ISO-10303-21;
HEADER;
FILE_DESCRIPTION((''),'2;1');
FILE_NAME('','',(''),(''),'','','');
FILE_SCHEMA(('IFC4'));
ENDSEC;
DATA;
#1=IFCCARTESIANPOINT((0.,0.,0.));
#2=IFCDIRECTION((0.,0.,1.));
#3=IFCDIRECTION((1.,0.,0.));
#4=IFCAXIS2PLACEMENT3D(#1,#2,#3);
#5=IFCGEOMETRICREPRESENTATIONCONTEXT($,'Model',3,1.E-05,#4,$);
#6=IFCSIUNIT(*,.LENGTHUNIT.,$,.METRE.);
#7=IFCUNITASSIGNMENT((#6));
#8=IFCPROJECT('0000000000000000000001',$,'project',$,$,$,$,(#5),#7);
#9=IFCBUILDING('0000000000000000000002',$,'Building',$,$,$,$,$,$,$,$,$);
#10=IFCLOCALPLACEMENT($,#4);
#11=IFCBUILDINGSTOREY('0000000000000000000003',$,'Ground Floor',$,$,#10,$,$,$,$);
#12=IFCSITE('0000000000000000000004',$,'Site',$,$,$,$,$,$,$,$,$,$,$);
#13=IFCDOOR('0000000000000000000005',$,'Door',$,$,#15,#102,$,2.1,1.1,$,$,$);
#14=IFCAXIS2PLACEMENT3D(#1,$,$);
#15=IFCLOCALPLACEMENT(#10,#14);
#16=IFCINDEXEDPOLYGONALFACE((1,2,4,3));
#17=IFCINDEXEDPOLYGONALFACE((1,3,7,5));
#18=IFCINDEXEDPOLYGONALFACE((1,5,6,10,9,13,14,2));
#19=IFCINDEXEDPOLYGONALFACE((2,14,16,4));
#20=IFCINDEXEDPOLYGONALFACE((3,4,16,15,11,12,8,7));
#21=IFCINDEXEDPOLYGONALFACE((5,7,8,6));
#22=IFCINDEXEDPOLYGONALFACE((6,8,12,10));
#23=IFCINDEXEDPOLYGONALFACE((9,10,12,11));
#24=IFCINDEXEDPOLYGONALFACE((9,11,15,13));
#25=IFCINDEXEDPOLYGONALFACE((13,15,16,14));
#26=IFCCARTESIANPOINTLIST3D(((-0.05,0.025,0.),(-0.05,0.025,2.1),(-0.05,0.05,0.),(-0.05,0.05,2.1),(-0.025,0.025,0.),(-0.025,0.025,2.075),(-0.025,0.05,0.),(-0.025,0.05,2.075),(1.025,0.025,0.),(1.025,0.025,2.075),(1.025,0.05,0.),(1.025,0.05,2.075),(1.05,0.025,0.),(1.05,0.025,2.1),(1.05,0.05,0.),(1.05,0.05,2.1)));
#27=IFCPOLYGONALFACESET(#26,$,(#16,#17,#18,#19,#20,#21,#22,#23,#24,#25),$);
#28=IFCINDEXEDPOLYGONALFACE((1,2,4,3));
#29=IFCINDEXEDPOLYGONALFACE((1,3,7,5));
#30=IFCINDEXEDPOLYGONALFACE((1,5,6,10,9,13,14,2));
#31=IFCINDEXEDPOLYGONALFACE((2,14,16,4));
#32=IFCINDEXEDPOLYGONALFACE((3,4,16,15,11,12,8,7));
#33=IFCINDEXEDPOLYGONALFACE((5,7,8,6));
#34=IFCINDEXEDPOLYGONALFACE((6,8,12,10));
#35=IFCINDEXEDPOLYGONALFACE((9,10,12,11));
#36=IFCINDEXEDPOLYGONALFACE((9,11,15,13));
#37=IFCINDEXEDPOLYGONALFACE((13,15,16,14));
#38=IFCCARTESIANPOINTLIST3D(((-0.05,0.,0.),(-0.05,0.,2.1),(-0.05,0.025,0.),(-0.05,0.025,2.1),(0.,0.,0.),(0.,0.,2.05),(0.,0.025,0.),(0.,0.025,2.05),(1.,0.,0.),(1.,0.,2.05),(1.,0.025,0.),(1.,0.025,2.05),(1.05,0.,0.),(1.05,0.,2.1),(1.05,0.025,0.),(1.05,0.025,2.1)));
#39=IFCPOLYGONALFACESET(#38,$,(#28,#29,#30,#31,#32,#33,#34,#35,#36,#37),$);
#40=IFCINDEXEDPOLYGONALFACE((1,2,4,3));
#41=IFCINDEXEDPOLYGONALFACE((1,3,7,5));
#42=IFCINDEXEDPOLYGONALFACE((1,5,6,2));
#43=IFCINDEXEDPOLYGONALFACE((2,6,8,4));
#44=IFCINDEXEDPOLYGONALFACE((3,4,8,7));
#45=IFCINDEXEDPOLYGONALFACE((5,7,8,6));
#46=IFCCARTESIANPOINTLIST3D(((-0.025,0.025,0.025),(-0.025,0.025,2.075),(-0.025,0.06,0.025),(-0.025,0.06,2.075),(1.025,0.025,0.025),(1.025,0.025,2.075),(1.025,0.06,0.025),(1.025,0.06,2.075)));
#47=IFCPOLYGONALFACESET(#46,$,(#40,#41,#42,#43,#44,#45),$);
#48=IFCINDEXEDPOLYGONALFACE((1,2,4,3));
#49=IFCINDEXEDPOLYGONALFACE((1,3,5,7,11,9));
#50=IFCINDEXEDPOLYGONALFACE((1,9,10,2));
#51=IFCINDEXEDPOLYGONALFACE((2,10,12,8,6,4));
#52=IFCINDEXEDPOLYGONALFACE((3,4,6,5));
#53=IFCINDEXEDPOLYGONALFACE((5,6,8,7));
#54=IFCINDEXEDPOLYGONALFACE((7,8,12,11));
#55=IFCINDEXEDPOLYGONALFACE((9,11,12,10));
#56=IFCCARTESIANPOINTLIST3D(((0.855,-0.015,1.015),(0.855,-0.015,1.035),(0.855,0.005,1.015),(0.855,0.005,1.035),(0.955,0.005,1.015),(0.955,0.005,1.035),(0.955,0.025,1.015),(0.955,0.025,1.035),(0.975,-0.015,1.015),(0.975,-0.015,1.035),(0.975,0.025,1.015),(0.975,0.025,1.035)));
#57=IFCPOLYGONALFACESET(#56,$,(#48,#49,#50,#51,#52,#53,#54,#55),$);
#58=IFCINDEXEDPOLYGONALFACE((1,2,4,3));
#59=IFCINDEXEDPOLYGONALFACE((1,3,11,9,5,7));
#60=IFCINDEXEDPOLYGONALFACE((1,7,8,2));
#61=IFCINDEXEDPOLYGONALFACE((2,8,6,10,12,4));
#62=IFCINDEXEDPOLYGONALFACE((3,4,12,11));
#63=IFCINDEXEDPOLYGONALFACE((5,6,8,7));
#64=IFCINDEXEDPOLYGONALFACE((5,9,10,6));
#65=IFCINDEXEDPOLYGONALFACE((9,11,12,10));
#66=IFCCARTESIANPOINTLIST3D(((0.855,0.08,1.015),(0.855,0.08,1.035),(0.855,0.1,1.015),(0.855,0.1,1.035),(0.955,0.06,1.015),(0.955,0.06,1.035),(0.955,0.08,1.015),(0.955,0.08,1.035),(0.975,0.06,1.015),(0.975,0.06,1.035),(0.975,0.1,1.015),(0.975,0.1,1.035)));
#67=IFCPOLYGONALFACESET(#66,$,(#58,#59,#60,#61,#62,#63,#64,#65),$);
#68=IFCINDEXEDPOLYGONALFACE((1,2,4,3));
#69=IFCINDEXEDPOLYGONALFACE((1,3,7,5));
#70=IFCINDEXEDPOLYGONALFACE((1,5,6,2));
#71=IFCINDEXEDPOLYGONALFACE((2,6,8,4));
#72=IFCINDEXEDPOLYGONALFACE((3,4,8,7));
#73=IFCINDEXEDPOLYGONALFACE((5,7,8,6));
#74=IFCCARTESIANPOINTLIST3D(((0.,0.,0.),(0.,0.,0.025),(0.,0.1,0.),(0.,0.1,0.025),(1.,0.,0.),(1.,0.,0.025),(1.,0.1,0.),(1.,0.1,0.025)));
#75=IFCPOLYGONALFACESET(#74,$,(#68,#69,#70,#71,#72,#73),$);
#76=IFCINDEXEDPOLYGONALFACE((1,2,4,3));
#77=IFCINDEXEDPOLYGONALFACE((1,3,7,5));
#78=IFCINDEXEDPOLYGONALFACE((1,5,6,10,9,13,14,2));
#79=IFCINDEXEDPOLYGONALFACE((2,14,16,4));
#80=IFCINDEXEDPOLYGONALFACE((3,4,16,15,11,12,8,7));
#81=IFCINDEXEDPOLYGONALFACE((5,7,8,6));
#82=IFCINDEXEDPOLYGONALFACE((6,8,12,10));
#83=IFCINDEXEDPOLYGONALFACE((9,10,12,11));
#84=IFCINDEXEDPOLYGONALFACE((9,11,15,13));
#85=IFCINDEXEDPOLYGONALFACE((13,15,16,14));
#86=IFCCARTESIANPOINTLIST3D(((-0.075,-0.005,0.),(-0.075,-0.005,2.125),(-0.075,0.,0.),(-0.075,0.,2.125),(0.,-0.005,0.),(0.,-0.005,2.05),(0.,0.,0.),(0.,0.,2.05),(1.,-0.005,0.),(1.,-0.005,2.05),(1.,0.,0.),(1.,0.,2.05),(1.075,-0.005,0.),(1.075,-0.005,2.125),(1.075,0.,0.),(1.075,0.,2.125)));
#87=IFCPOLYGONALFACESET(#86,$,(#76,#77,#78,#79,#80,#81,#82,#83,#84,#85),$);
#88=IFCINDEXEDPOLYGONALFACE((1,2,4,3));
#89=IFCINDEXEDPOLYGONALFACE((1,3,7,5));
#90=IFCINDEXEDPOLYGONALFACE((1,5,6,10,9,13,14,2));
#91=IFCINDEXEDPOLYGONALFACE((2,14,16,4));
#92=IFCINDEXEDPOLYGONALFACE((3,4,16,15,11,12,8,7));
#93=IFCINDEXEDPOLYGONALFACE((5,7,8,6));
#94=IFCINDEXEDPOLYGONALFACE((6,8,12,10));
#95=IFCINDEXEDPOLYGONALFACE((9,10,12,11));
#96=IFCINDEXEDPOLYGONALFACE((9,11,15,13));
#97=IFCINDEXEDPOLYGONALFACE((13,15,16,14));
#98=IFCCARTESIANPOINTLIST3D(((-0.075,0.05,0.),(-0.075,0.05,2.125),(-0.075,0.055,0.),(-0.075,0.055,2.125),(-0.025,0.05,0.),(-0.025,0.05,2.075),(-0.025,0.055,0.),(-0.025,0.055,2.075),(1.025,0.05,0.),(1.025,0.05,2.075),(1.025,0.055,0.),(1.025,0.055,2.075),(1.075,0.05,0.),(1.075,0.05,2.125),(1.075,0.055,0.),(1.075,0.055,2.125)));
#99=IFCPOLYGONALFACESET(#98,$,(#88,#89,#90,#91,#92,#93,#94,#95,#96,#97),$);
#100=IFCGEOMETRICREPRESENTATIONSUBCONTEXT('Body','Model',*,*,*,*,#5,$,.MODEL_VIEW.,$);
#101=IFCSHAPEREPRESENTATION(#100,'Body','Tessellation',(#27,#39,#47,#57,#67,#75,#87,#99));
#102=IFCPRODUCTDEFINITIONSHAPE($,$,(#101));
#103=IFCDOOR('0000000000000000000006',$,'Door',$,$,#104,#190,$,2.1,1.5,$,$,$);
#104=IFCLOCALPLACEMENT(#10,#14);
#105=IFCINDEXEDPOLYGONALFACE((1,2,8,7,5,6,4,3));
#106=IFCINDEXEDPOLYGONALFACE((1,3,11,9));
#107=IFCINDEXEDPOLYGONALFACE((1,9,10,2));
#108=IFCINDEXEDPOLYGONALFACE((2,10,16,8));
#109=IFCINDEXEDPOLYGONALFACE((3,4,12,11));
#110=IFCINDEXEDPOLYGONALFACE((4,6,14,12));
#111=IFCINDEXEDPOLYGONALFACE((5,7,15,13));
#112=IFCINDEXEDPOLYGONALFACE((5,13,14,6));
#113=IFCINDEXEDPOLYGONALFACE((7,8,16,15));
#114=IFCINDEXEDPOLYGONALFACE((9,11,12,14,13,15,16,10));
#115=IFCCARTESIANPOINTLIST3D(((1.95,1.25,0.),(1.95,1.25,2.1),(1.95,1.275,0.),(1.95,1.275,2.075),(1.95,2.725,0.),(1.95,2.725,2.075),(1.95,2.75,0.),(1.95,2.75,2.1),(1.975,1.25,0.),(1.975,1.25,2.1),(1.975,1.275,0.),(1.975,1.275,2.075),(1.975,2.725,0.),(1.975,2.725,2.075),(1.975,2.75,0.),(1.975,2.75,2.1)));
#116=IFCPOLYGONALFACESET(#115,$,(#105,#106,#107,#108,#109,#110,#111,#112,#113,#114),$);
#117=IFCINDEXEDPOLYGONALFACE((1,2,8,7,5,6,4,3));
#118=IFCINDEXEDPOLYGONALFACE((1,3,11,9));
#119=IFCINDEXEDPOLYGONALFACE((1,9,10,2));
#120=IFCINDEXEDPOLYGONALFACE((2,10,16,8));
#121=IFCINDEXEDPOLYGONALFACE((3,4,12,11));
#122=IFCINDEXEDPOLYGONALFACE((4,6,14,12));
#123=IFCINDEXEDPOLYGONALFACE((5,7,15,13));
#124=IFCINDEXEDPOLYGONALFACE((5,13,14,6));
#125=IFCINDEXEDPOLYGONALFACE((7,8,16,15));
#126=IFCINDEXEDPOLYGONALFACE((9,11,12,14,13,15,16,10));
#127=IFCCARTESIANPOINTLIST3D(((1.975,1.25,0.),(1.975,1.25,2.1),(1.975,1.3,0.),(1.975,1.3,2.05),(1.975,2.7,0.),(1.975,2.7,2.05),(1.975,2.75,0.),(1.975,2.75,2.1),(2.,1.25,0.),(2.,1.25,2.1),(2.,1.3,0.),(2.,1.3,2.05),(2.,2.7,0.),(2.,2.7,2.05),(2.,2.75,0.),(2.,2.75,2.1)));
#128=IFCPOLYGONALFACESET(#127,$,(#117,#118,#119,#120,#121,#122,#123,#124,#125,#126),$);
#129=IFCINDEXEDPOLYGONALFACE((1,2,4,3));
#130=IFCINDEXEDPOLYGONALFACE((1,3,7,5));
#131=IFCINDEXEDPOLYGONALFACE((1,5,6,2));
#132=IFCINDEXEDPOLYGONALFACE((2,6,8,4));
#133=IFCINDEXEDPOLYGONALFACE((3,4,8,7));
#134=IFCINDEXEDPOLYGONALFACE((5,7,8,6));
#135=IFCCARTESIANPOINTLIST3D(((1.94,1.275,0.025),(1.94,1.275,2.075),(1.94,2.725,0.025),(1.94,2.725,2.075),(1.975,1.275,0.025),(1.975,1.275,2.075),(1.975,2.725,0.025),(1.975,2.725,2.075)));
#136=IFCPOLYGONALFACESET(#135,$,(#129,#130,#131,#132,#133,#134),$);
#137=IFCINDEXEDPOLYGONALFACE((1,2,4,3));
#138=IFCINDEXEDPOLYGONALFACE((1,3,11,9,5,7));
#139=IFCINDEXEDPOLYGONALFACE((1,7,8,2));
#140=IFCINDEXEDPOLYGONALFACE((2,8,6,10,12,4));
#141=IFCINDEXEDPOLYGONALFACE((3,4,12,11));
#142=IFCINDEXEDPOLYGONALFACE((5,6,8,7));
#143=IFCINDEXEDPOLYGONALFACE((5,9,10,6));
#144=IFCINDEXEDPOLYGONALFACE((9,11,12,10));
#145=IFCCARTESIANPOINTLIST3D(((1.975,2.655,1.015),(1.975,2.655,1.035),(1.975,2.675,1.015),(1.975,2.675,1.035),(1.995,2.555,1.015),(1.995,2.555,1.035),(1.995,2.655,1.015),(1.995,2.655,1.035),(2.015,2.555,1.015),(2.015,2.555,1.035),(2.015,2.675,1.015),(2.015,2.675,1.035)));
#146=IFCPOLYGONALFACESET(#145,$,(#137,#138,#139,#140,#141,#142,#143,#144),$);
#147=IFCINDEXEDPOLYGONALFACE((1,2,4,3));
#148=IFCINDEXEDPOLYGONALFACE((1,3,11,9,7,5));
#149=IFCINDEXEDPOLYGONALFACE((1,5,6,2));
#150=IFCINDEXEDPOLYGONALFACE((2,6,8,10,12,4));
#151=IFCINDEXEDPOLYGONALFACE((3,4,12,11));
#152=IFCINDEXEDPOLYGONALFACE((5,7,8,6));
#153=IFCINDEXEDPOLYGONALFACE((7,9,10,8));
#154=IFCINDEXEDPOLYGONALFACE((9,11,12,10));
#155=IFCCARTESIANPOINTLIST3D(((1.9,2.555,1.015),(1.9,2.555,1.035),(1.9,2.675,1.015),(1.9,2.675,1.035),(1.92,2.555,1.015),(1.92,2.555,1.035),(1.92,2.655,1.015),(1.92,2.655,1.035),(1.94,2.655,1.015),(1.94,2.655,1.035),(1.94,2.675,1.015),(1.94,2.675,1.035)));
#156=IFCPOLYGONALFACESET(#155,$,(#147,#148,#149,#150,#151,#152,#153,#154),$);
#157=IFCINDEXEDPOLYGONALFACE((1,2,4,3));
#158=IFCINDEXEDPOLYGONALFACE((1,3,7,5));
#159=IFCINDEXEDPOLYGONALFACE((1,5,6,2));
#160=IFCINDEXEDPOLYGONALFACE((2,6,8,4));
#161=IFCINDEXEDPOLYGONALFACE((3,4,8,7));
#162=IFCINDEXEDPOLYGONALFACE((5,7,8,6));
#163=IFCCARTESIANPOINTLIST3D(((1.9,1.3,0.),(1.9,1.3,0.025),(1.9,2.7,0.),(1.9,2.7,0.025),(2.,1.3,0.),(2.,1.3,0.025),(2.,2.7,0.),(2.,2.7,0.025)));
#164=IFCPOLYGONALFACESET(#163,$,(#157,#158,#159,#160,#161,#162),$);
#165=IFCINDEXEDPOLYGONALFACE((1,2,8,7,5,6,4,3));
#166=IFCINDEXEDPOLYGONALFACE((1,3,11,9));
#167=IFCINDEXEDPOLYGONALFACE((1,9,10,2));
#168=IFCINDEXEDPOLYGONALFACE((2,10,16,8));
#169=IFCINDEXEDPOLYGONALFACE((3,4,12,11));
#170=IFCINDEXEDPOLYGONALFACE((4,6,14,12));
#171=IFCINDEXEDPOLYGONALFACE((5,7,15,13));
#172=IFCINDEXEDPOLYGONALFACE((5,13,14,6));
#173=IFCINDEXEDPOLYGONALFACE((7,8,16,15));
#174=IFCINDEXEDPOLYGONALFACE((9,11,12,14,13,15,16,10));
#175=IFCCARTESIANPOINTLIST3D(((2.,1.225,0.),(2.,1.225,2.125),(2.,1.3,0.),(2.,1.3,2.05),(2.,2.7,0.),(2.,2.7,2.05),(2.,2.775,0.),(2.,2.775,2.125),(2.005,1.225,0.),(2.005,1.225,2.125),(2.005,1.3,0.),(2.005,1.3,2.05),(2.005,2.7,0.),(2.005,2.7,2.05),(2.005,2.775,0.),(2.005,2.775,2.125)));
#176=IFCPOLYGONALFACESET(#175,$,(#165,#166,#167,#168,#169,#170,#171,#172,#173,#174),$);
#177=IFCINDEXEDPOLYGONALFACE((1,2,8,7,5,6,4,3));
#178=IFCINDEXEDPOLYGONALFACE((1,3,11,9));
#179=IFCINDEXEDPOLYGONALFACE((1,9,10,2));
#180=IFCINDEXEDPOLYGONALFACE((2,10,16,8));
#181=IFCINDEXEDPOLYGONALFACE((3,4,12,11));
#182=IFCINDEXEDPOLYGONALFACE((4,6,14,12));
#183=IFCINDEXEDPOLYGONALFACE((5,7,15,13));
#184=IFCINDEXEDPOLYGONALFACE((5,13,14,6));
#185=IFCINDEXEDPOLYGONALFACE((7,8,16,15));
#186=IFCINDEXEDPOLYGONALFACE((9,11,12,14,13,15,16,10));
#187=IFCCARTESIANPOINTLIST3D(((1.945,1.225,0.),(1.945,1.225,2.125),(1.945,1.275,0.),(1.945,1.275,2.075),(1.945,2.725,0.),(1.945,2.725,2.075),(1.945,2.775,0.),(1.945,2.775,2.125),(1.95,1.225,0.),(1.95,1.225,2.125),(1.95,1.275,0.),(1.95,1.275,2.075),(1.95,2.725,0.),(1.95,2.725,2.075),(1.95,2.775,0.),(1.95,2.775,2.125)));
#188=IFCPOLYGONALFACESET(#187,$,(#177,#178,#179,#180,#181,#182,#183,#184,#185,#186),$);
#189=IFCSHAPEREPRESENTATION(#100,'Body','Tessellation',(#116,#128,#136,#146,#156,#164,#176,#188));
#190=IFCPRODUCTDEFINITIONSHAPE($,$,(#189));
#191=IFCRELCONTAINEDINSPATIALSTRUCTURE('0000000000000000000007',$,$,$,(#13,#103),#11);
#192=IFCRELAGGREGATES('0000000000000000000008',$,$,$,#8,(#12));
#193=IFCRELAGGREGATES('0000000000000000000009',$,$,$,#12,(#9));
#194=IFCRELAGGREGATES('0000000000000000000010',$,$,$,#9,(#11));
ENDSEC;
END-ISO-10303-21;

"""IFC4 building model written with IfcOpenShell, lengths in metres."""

from ifc_helpers import new_model, si_unit, frame, origin_with_axes, place, context, subcontext, project, spatial, line, indexed_curve, outline, extrude, element, save


model = new_model("IFC4")

# Units and contexts
model_context = context("Model", 3, precision=1e-05, world=origin_with_axes())
body_context = subcontext(model_context, "Body", "Model", "MODEL_VIEW")
ifc_project = project(units=[si_unit("LENGTHUNIT", "METRE")], contexts=[model_context])

# Site, building, storey
site = spatial("IfcSite", under=ifc_project, Name="Site")
building = spatial("IfcBuilding", under=site, Name="Building")
storey_placement = place(None, origin_with_axes())
storey = spatial("IfcBuildingStorey", under=building, at=storey_placement, Name="Ground Floor")

# Doors
door_1_placement = place(storey_placement, frame((-0.05, 0.0, 0.0), z_axis=(0.0, 0.0, 1.0), x_axis=(1.0, 0.0, 0.0)))
element("IfcDoor", 1, at=door_1_placement, inside=storey, Name="Door", OverallHeight=2.1, OverallWidth=1.1, context=body_context, shape_type="SweptSolid", body=[
    extrude(outline(indexed_curve([(0.0, 0.0), (0.0, 2.1), (1.1, 2.1), (1.1, 0.0), (1.075, 0.0), (1.075, 2.075), (0.025, 2.075), (0.025, 0.0)], segments=[line(1, 2, 3, 4, 5, 6, 7, 8, 1)])), frame((0.0, 0.025, 0.0), z_axis=(0.0, -1.0, 0.0), x_axis=(1.0, 0.0, 0.0)), (0.0, 0.0, -1.0), 0.025),
    extrude(outline(indexed_curve([(0.0, 0.0), (0.0, 2.1), (1.1, 2.1), (1.1, 0.0), (1.05, 0.0), (1.05, 2.05), (0.05, 2.05), (0.05, 0.0)], segments=[line(1, 2, 3, 4, 5, 6, 7, 8, 1)])), frame((0.0, 0.0, 0.0), z_axis=(0.0, -1.0, 0.0), x_axis=(1.0, 0.0, 0.0)), (0.0, 0.0, -1.0), 0.025),
    extrude(outline(indexed_curve([(0.0, 0.0), (1.05, 0.0), (1.05, 0.035), (0.0, 0.035)], segments=[line(1, 2, 3, 4, 1)])), frame((0.025, 0.025, 0.025), z_axis=(0.0, 0.0, 1.0), x_axis=(1.0, 0.0, 0.0)), (0.0, 0.0, 1.0), 2.05),
    extrude(outline(indexed_curve([(0.0, 0.0), (0.0, -0.04), (-0.12, -0.04), (-0.12, -0.02), (-0.02, -0.02), (-0.02, 0.0)], segments=[line(1, 2, 3, 4, 5, 6, 1)])), frame((1.025, 0.025, 1.015), z_axis=(0.0, 0.0, 1.0), x_axis=(1.0, 0.0, 0.0)), (0.0, 0.0, 1.0), 0.02),
    extrude(outline(indexed_curve([(0.0, 0.0), (0.0, 0.04), (-0.12, 0.04), (-0.12, 0.02), (-0.02, 0.02), (-0.02, 0.0)], segments=[line(1, 2, 3, 4, 5, 6, 1)])), frame((1.025, 0.06, 1.015), z_axis=(0.0, 0.0, 1.0), x_axis=(1.0, 0.0, 0.0)), (0.0, 0.0, 1.0), 0.02),
    extrude(outline(indexed_curve([(0.0, 0.0), (1.0, 0.0), (1.0, 0.1), (0.0, 0.1)], segments=[line(1, 2, 3, 4, 1)])), frame((0.05, 0.0, 0.0), z_axis=(0.0, 0.0, 1.0), x_axis=(1.0, 0.0, 0.0)), (0.0, 0.0, 1.0), 0.025),
    extrude(outline(indexed_curve([(0.0, 0.0), (0.0, 2.125), (1.15, 2.125), (1.15, 0.0), (1.075, 0.0), (1.075, 2.05), (0.075, 2.05), (0.075, 0.0)], segments=[line(1, 2, 3, 4, 5, 6, 7, 8, 1)])), frame((-0.025, -0.005, 0.0), z_axis=(0.0, -1.0, 0.0), x_axis=(1.0, 0.0, 0.0)), (0.0, 0.0, -1.0), 0.005),
    extrude(outline(indexed_curve([(0.0, 0.0), (0.0, 2.125), (1.15, 2.125), (1.15, 0.0), (1.1, 0.0), (1.1, 2.075), (0.05, 2.075), (0.05, 0.0)], segments=[line(1, 2, 3, 4, 5, 6, 7, 8, 1)])), frame((-0.025, 0.05, 0.0), z_axis=(0.0, -1.0, 0.0), x_axis=(1.0, 0.0, 0.0)), (0.0, 0.0, -1.0), 0.005),
])
door_2_placement = place(storey_placement, frame((2.0, 1.25, 0.0), z_axis=(0.0, 0.0, 1.0), x_axis=(0.0, 1.0, 0.0)))
element("IfcDoor", 2, at=door_2_placement, inside=storey, Name="Door", OverallHeight=2.1, OverallWidth=1.5, context=body_context, shape_type="SweptSolid", body=[
    extrude(outline(indexed_curve([(0.0, 0.0), (0.0, 2.1), (1.5, 2.1), (1.5, 0.0), (1.475, 0.0), (1.475, 2.075), (0.025, 2.075), (0.025, 0.0)], segments=[line(1, 2, 3, 4, 5, 6, 7, 8, 1)])), frame((0.0, 0.025, 0.0), z_axis=(0.0, -1.0, 0.0), x_axis=(1.0, 0.0, 0.0)), (0.0, 0.0, -1.0), 0.025),
    extrude(outline(indexed_curve([(0.0, 0.0), (0.0, 2.1), (1.5, 2.1), (1.5, 0.0), (1.45, 0.0), (1.45, 2.05), (0.05, 2.05), (0.05, 0.0)], segments=[line(1, 2, 3, 4, 5, 6, 7, 8, 1)])), frame((0.0, 0.0, 0.0), z_axis=(0.0, -1.0, 0.0), x_axis=(1.0, 0.0, 0.0)), (0.0, 0.0, -1.0), 0.025),
    extrude(outline(indexed_curve([(0.0, 0.0), (1.45, 0.0), (1.45, 0.035), (0.0, 0.035)], segments=[line(1, 2, 3, 4, 1)])), frame((0.025, 0.025, 0.025), z_axis=(0.0, 0.0, 1.0), x_axis=(1.0, 0.0, 0.0)), (0.0, 0.0, 1.0), 2.05),
    extrude(outline(indexed_curve([(0.0, 0.0), (0.0, -0.04), (-0.12, -0.04), (-0.12, -0.02), (-0.02, -0.02), (-0.02, 0.0)], segments=[line(1, 2, 3, 4, 5, 6, 1)])), frame((1.425, 0.025, 1.015), z_axis=(0.0, 0.0, 1.0), x_axis=(1.0, 0.0, 0.0)), (0.0, 0.0, 1.0), 0.02),
    extrude(outline(indexed_curve([(0.0, 0.0), (0.0, 0.04), (-0.12, 0.04), (-0.12, 0.02), (-0.02, 0.02), (-0.02, 0.0)], segments=[line(1, 2, 3, 4, 5, 6, 1)])), frame((1.425, 0.06, 1.015), z_axis=(0.0, 0.0, 1.0), x_axis=(1.0, 0.0, 0.0)), (0.0, 0.0, 1.0), 0.02),
    extrude(outline(indexed_curve([(0.0, 0.0), (1.4, 0.0), (1.4, 0.1), (0.0, 0.1)], segments=[line(1, 2, 3, 4, 1)])), frame((0.05, 0.0, 0.0), z_axis=(0.0, 0.0, 1.0), x_axis=(1.0, 0.0, 0.0)), (0.0, 0.0, 1.0), 0.025),
    extrude(outline(indexed_curve([(0.0, 0.0), (0.0, 2.125), (1.55, 2.125), (1.55, 0.0), (1.475, 0.0), (1.475, 2.05), (0.075, 2.05), (0.075, 0.0)], segments=[line(1, 2, 3, 4, 5, 6, 7, 8, 1)])), frame((-0.025, -0.005, 0.0), z_axis=(0.0, -1.0, 0.0), x_axis=(1.0, 0.0, 0.0)), (0.0, 0.0, -1.0), 0.005),
    extrude(outline(indexed_curve([(0.0, 0.0), (0.0, 2.125), (1.55, 2.125), (1.55, 0.0), (1.5, 0.0), (1.5, 2.075), (0.05, 2.075), (0.05, 0.0)], segments=[line(1, 2, 3, 4, 5, 6, 7, 8, 1)])), frame((-0.025, 0.05, 0.0), z_axis=(0.0, -1.0, 0.0), x_axis=(1.0, 0.0, 0.0)), (0.0, 0.0, -1.0), 0.005),
])

save(model, "model.ifc")
